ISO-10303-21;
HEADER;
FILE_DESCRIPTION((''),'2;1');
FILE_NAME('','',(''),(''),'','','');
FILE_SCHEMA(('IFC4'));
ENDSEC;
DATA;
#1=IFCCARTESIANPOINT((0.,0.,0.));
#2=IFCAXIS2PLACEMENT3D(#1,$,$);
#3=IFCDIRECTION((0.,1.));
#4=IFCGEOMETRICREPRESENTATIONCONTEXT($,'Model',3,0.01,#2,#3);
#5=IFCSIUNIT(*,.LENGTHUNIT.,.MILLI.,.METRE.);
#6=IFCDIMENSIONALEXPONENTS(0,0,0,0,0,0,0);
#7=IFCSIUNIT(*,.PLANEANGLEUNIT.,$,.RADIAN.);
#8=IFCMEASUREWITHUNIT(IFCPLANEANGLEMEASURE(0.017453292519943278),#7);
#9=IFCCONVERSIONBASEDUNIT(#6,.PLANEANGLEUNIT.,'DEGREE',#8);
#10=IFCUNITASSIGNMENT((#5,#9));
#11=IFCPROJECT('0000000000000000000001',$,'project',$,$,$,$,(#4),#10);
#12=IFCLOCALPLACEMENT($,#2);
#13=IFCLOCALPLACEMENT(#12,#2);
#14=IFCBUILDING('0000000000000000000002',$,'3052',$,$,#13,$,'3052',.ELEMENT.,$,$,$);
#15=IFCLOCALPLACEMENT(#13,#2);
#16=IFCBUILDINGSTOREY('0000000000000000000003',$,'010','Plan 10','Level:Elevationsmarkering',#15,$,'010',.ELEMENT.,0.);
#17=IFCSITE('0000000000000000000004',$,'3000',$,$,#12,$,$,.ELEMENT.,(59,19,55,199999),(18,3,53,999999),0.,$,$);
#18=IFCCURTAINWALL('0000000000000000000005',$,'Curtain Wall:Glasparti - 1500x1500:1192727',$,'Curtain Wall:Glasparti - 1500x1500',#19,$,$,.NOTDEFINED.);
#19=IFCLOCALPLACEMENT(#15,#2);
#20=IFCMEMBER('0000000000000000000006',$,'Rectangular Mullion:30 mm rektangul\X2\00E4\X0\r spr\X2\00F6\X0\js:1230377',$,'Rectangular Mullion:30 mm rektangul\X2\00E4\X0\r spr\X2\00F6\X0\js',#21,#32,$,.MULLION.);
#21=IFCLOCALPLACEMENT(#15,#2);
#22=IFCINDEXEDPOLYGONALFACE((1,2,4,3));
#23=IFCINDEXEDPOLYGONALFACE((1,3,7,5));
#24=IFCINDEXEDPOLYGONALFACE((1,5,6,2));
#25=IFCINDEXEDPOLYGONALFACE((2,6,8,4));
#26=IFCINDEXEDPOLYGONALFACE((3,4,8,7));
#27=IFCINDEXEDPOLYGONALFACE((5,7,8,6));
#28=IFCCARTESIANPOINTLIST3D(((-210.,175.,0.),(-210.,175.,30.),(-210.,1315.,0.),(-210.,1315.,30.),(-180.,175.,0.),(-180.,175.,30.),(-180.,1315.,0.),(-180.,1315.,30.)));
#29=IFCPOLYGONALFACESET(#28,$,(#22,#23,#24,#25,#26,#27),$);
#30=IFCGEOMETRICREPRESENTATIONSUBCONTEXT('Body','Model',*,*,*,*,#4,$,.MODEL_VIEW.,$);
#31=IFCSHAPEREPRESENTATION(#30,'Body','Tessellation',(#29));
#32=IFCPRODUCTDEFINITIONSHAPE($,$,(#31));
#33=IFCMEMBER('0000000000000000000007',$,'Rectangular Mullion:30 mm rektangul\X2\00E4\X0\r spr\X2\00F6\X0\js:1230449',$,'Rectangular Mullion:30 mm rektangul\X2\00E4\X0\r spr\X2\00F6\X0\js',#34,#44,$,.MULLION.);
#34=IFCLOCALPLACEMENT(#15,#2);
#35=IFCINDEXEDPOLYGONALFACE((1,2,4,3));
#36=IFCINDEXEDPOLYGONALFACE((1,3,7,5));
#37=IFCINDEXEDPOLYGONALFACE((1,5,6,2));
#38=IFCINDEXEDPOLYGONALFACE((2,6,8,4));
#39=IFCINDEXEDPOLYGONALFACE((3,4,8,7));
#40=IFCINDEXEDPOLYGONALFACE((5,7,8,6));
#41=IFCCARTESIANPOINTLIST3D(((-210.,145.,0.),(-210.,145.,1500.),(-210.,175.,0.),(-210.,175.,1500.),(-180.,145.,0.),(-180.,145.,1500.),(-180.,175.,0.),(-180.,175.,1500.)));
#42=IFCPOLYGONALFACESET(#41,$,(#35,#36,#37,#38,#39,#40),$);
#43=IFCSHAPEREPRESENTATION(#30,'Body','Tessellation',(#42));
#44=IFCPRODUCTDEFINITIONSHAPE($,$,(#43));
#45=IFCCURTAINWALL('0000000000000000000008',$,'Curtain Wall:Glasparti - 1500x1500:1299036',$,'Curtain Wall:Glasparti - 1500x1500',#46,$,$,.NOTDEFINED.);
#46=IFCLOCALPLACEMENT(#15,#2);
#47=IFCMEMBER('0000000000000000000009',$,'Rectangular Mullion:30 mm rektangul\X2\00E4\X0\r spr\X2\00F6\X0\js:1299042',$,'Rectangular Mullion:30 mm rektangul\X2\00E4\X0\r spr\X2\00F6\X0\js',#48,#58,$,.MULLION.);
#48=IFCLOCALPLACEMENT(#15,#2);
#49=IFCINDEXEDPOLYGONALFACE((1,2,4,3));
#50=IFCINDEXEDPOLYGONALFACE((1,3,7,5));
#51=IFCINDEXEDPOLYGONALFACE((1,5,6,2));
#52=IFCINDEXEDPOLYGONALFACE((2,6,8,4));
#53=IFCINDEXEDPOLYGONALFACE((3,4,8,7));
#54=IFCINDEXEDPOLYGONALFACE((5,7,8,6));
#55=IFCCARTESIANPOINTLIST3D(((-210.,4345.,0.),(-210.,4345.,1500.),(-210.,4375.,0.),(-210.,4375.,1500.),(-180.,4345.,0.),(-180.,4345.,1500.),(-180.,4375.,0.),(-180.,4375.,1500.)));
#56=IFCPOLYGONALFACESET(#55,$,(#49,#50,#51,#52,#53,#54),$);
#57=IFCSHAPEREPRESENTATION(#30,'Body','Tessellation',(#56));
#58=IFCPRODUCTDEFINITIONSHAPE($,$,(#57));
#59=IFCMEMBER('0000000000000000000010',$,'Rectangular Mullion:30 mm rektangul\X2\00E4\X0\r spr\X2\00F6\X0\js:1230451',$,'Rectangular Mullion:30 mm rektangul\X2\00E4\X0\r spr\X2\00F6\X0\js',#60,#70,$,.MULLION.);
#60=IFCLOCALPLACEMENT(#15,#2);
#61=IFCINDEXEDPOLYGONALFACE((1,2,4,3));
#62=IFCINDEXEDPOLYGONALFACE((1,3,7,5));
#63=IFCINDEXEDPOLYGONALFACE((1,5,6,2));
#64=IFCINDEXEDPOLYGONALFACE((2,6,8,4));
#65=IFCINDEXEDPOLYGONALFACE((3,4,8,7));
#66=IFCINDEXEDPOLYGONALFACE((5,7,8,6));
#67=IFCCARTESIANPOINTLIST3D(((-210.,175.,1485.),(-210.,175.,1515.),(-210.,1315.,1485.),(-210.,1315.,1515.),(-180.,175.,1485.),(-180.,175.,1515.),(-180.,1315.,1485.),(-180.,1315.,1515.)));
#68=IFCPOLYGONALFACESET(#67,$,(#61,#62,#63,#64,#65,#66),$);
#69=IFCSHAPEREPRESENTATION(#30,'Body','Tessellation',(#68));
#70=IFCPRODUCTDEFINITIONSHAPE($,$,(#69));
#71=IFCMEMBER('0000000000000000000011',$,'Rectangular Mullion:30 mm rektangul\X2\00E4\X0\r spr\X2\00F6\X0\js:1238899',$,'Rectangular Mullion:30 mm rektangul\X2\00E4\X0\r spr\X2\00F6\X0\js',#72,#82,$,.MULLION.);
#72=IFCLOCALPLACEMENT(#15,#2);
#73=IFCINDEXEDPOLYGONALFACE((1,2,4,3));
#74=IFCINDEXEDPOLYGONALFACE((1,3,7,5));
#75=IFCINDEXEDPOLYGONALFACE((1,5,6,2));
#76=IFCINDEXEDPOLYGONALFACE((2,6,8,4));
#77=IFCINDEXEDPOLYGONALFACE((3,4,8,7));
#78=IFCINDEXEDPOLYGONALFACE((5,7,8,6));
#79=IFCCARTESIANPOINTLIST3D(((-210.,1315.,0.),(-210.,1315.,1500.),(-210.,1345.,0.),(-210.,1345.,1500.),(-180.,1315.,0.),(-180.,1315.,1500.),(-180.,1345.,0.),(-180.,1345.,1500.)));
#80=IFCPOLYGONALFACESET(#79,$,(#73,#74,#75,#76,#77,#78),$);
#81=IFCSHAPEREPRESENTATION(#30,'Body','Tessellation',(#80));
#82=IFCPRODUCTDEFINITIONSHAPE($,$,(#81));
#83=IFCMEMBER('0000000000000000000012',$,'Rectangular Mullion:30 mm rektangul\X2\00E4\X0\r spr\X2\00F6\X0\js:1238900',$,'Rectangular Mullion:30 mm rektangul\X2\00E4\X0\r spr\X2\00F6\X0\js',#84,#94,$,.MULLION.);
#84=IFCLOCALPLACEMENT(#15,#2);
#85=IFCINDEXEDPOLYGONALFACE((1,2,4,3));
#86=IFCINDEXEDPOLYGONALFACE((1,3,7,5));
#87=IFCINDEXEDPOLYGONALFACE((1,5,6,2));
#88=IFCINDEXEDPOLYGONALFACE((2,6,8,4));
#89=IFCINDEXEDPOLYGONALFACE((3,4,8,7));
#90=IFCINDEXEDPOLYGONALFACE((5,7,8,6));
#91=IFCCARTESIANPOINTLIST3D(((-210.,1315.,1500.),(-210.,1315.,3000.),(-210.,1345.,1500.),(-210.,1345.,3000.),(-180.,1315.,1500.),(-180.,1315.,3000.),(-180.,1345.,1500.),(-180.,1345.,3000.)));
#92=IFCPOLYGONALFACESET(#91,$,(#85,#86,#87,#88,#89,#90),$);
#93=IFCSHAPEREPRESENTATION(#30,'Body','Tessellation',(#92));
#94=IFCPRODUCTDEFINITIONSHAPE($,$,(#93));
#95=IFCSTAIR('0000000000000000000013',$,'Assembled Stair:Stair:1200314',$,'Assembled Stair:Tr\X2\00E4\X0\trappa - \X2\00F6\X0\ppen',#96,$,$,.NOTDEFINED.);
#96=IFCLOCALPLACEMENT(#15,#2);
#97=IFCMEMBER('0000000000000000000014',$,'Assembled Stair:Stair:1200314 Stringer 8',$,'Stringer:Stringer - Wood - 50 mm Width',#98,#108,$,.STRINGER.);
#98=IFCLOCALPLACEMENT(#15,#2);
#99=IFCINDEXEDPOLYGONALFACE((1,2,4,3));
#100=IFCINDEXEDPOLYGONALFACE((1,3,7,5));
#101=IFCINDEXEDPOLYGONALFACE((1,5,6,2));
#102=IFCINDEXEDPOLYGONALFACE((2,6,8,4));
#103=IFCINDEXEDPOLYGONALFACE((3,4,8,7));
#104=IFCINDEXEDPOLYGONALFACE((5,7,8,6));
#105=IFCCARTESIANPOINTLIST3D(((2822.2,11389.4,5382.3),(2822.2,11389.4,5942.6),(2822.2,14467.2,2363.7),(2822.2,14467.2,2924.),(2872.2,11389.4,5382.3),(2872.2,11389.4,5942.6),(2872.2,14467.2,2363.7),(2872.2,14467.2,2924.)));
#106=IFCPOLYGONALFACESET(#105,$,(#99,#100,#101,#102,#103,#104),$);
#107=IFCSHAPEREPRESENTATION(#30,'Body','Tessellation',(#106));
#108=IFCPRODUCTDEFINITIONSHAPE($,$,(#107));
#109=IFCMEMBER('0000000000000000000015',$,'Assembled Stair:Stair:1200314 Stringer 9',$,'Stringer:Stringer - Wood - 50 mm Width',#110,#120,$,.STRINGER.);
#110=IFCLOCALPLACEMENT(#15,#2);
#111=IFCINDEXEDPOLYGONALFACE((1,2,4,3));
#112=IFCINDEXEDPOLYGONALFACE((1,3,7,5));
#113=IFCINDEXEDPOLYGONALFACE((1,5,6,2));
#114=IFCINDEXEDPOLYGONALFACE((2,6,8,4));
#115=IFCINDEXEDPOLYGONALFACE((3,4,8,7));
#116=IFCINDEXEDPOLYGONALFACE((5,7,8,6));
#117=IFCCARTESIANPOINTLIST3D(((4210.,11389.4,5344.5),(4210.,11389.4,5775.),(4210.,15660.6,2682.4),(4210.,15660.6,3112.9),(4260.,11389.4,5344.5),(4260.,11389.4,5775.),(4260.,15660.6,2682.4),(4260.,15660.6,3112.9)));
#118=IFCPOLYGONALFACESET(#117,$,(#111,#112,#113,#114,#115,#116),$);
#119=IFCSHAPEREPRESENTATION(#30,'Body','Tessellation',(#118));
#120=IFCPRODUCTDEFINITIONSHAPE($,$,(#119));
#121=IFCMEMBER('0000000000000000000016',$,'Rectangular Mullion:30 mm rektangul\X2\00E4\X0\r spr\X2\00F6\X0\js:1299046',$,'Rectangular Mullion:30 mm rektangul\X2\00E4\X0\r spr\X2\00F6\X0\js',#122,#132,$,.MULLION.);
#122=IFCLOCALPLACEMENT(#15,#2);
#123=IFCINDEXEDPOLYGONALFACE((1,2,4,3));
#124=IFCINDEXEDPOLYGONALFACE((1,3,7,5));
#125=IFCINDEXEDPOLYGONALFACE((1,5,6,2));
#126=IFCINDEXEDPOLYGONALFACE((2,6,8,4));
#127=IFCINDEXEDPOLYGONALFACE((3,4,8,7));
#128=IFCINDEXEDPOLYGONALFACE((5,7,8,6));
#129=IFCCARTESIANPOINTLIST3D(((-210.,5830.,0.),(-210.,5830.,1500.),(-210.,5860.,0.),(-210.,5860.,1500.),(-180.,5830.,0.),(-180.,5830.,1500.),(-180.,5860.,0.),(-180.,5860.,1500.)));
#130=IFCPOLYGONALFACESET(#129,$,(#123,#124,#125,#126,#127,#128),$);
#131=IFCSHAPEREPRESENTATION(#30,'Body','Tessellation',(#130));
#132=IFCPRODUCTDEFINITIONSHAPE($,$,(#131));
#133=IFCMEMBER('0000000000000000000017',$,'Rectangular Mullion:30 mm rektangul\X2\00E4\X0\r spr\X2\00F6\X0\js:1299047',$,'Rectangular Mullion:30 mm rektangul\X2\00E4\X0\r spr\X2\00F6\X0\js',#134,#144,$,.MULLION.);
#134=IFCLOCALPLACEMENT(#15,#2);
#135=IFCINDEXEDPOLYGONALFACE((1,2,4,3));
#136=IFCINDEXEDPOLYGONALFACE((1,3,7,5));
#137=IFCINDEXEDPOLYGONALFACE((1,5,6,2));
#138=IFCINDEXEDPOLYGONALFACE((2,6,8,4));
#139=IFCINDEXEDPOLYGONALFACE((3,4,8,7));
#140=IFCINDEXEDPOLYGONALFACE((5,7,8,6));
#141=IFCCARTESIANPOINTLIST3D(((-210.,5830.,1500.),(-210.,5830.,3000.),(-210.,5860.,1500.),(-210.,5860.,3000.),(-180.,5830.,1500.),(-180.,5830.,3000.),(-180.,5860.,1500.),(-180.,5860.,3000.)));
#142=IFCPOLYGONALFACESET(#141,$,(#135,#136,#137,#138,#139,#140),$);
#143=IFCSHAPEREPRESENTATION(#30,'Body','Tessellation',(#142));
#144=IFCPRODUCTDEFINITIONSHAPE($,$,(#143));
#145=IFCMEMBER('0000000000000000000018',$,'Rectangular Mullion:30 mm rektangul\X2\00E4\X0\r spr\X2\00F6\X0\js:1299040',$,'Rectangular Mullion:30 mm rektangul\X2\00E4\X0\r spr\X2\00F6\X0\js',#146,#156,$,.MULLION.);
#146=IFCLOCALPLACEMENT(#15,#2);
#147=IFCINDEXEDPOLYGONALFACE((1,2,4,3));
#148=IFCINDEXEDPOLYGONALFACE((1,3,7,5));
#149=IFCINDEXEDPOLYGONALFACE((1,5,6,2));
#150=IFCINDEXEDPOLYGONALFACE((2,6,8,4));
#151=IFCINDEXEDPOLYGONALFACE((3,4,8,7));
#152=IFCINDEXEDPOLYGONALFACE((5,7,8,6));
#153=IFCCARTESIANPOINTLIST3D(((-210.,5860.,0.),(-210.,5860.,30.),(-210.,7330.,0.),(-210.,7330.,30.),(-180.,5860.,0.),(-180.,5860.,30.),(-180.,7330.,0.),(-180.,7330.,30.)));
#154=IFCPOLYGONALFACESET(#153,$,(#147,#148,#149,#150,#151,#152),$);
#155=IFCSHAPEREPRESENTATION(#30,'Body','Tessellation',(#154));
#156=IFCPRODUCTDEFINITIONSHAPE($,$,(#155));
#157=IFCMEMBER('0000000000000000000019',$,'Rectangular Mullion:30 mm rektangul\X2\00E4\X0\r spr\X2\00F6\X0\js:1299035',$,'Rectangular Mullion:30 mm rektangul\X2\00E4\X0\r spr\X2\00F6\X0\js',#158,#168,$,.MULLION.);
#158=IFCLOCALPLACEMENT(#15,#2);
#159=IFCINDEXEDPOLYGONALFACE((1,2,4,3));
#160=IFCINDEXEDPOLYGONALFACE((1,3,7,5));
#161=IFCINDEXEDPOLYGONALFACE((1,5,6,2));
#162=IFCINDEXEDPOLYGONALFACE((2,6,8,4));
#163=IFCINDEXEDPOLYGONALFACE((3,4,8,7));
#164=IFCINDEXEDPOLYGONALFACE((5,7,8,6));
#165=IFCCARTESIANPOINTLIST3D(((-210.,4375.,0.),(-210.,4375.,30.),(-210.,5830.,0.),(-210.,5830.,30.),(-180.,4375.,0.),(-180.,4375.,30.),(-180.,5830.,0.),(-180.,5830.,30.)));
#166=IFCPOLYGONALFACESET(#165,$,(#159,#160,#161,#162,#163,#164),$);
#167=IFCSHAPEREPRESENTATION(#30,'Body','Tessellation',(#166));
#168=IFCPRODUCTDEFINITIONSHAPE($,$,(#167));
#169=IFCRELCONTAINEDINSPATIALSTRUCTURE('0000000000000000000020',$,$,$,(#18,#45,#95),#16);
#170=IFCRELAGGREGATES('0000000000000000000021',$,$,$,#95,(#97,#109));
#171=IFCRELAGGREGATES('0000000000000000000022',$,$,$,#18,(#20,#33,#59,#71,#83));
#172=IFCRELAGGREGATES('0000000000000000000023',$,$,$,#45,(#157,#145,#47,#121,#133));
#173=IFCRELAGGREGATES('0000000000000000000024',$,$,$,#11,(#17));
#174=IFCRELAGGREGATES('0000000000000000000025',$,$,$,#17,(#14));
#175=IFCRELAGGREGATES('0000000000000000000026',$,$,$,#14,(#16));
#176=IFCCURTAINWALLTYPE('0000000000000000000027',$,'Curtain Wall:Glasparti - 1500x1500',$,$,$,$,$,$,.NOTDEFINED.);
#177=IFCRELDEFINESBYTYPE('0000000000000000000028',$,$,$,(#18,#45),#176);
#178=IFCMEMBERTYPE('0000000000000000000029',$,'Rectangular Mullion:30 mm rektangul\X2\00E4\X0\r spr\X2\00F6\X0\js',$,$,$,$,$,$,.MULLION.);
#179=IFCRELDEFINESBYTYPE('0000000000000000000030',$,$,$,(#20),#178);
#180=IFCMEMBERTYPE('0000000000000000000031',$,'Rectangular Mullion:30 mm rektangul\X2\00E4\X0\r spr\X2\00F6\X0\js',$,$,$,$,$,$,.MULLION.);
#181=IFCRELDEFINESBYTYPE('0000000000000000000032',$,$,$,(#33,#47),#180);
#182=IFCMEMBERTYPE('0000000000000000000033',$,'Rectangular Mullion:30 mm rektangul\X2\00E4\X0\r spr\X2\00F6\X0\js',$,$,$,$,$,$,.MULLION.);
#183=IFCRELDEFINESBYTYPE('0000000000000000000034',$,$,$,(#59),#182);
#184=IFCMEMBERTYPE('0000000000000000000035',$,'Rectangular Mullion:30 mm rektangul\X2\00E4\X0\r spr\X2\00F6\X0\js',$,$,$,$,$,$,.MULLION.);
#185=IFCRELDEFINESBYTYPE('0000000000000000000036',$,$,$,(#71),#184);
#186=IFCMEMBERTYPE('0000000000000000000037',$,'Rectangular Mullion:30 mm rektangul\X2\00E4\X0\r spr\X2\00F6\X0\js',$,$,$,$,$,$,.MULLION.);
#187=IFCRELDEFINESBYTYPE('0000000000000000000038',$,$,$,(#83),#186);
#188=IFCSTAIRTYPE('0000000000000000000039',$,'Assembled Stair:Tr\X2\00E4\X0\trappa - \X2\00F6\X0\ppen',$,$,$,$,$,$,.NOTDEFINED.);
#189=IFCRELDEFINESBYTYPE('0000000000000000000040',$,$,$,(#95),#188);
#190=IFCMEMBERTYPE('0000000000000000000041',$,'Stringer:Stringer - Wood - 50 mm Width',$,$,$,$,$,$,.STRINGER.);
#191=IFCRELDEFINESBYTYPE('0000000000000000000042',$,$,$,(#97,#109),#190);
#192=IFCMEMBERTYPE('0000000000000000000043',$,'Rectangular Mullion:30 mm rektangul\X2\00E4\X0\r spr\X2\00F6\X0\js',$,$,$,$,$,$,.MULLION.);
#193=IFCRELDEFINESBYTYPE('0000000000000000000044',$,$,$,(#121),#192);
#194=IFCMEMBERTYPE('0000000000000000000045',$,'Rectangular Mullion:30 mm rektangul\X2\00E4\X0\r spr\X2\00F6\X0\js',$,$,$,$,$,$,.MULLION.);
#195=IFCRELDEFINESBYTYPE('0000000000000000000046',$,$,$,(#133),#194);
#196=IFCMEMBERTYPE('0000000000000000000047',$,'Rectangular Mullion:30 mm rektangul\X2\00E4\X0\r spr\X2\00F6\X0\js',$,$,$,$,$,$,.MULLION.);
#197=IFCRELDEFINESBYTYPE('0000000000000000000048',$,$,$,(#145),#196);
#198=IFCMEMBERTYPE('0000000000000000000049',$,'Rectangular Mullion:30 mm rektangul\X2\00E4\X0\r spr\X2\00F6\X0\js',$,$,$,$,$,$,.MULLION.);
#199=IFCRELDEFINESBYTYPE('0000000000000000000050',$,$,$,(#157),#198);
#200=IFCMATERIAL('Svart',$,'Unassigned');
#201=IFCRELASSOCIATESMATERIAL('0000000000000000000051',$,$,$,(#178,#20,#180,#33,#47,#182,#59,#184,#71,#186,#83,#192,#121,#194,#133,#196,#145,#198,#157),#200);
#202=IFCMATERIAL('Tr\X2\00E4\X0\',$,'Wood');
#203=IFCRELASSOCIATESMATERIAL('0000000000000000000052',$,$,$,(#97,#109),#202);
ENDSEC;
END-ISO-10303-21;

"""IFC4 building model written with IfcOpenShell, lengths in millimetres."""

from ifc_helpers import new_model, entity, si_unit, converted_unit, direction, frame, origin, place, context, subcontext, project, spatial, indexed_curve, outline, extrude, source, transform, mapped, material, type_object, type_shapes, element, aggregate, save


model = new_model("IFC4")

# Units and contexts
model_context = context("Model", 3, precision=0.01, world=origin(), true_north=direction((0.0, 1.0)))
body_context = subcontext(model_context, "Body", "Model", "MODEL_VIEW")
ifc_project = project(units=[si_unit("LENGTHUNIT", "METRE", prefix="MILLI"), converted_unit("PLANEANGLEUNIT", "DEGREE", entity("IfcPlaneAngleMeasure", 0.017453292519943278), si_unit("PLANEANGLEUNIT", "RADIAN"), dimensions=[0, 0, 0, 0, 0, 0, 0])], contexts=[model_context])

# Site, building, storey
site_placement = place(None, origin())
site = spatial("IfcSite", under=ifc_project, at=site_placement, Name="3000", CompositionType="ELEMENT", RefLatitude=(59, 19, 55, 199999), RefLongitude=(18, 3, 53, 999999), RefElevation=0.0)
building_placement = place(site_placement, origin())
building = spatial("IfcBuilding", under=site, at=building_placement, Name="3052", LongName="3052", CompositionType="ELEMENT")
storey_placement = place(building_placement, origin())
storey = spatial("IfcBuildingStorey", under=building, at=storey_placement, Name="010", Description="Plan 10", ObjectType="Level:Elevationsmarkering", LongName="010", CompositionType="ELEMENT", Elevation=0.0)

# Curtain wall, members
curtain_wall_type = type_object("IfcCurtainWallType", Name="Curtain Wall:Glasparti - 1500x1500", PredefinedType="NOTDEFINED")
curtain_wall_1_placement = place(storey_placement, origin())
curtain_wall_1 = element("IfcCurtainWall", 1, at=curtain_wall_1_placement, inside=storey, type_object=curtain_wall_type, Name="Curtain Wall:Glasparti - 1500x1500:1192727", ObjectType="Curtain Wall:Glasparti - 1500x1500", PredefinedType="NOTDEFINED")
ifc_material_1 = material(Name="Svart", Category="Unassigned")
member_type_1 = type_object("IfcMemberType", Name="Rectangular Mullion:30 mm rektangulär spröjs", PredefinedType="MULLION", material=ifc_material_1)
shared_shape_1 = source(origin(), body_context, "Body", "SweptSolid", [
    extrude(outline(indexed_curve([(-15.0, -15.0), (15.0, -15.0), (15.0, 15.0), (-15.0, 15.0), (-15.0, -15.0)], self_intersect=False)), frame((-15.0, 0.0, -1140.0), z_axis=(0.0, 0.0, 1.0), x_axis=(-1.0, 0.0, 0.0)), (0.0, 0.0, 1.0), 1140.0),
])
type_shapes(member_type_1, [shared_shape_1])
member_1_placement = place(curtain_wall_1_placement, frame((-195.0, 175.0, 0.0), z_axis=(0.0, -1.0, 0.0), x_axis=(0.0, 0.0, -1.0)))
member_1 = element("IfcMember", 2, at=member_1_placement, type_object=member_type_1, material=ifc_material_1, Name="Rectangular Mullion:30 mm rektangulär spröjs:1230377", ObjectType="Rectangular Mullion:30 mm rektangulär spröjs", PredefinedType="MULLION", context=body_context, shape_type="MappedRepresentation", body=[
    mapped(shared_shape_1, transform((0.0, 0.0, 0.0), scale=1.0)),
])
member_type_2 = type_object("IfcMemberType", Name="Rectangular Mullion:30 mm rektangulär spröjs", PredefinedType="MULLION", material=ifc_material_1)
shared_shape_2 = source(origin(), body_context, "Body", "SweptSolid", [
    extrude(outline(indexed_curve([(-15.0, -15.0), (15.0, -15.0), (15.0, 15.0), (-15.0, 15.0), (-15.0, -15.0)], self_intersect=False)), frame((-15.0, 0.0, -1500.0), z_axis=(0.0, 0.0, 1.0), x_axis=(-1.0, 0.0, 0.0)), (0.0, 0.0, 1.0), 1500.0),
])
type_shapes(member_type_2, [shared_shape_2])
member_2_placement = place(curtain_wall_1_placement, frame((-195.0, 145.0, 1500.0), z_axis=(0.0, 0.0, 1.0), x_axis=(0.0, -1.0, 0.0)))
member_2 = element("IfcMember", 3, at=member_2_placement, type_object=member_type_2, material=ifc_material_1, Name="Rectangular Mullion:30 mm rektangulär spröjs:1230449", ObjectType="Rectangular Mullion:30 mm rektangulär spröjs", PredefinedType="MULLION", context=body_context, shape_type="MappedRepresentation", body=[
    mapped(shared_shape_2, transform((0.0, 0.0, 0.0), scale=1.0)),
])

# Curtain wall, member
curtain_wall_2_placement = place(storey_placement, origin())
curtain_wall_2 = element("IfcCurtainWall", 4, at=curtain_wall_2_placement, inside=storey, type_object=curtain_wall_type, Name="Curtain Wall:Glasparti - 1500x1500:1299036", ObjectType="Curtain Wall:Glasparti - 1500x1500", PredefinedType="NOTDEFINED")
member_3_placement = place(curtain_wall_2_placement, frame((-195.0, 4345.0, 1500.0), z_axis=(0.0, 0.0, 1.0), x_axis=(0.0, -1.0, 0.0)))
member_3 = element("IfcMember", 5, at=member_3_placement, type_object=member_type_2, material=ifc_material_1, Name="Rectangular Mullion:30 mm rektangulär spröjs:1299042", ObjectType="Rectangular Mullion:30 mm rektangulär spröjs", PredefinedType="MULLION", context=body_context, shape_type="MappedRepresentation", body=[
    mapped(shared_shape_2, transform((0.0, 0.0, 0.0), scale=1.0)),
])

# Members
member_type_3 = type_object("IfcMemberType", Name="Rectangular Mullion:30 mm rektangulär spröjs", PredefinedType="MULLION", material=ifc_material_1)
shared_shape_3 = source(origin(), body_context, "Body", "SweptSolid", [
    extrude(outline(indexed_curve([(-15.0, -15.0), (15.0, -15.0), (15.0, 15.0), (-15.0, 15.0), (-15.0, -15.0)], self_intersect=False)), frame((0.0, 0.0, -1140.0), z_axis=(0.0, 0.0, 1.0), x_axis=(-1.0, 0.0, 0.0)), (0.0, 0.0, 1.0), 1140.0),
])
type_shapes(member_type_3, [shared_shape_3])
member_4_placement = place(curtain_wall_1_placement, frame((-195.0, 1315.0, 1500.0), z_axis=(0.0, 1.0, 0.0), x_axis=(0.0, 0.0, 1.0)))
member_4 = element("IfcMember", 6, at=member_4_placement, type_object=member_type_3, material=ifc_material_1, Name="Rectangular Mullion:30 mm rektangulär spröjs:1230451", ObjectType="Rectangular Mullion:30 mm rektangulär spröjs", PredefinedType="MULLION", context=body_context, shape_type="MappedRepresentation", body=[
    mapped(shared_shape_3, transform((0.0, 0.0, 0.0), scale=1.0)),
])
member_type_4 = type_object("IfcMemberType", Name="Rectangular Mullion:30 mm rektangulär spröjs", PredefinedType="MULLION", material=ifc_material_1)
shared_shape_4 = source(origin(), body_context, "Body", "SweptSolid", [
    extrude(outline(indexed_curve([(-15.0, -15.0), (15.0, -15.0), (15.0, 15.0), (-15.0, 15.0), (-15.0, -15.0)], self_intersect=False)), frame((-15.0, 0.0, -1500.0), z_axis=(0.0, 0.0, 1.0), x_axis=(-1.0, 0.0, 0.0)), (0.0, 0.0, 1.0), 1500.0),
])
type_shapes(member_type_4, [shared_shape_4])
member_5_placement = place(curtain_wall_1_placement, frame((-195.0, 1345.0, 0.0), z_axis=(0.0, 0.0, -1.0), x_axis=(0.0, 1.0, 0.0)))
member_5 = element("IfcMember", 7, at=member_5_placement, type_object=member_type_4, material=ifc_material_1, Name="Rectangular Mullion:30 mm rektangulär spröjs:1238899", ObjectType="Rectangular Mullion:30 mm rektangulär spröjs", PredefinedType="MULLION", context=body_context, shape_type="MappedRepresentation", body=[
    mapped(shared_shape_4, transform((0.0, 0.0, 0.0), scale=1.0)),
])
member_type_5 = type_object("IfcMemberType", Name="Rectangular Mullion:30 mm rektangulär spröjs", PredefinedType="MULLION", material=ifc_material_1)
shared_shape_5 = source(origin(), body_context, "Body", "SweptSolid", [
    extrude(outline(indexed_curve([(-15.0, -15.0), (15.0, -15.0), (15.0, 15.0), (-15.0, 15.0), (-15.0, -15.0)], self_intersect=False)), frame((-15.0, 0.0, -1500.0), z_axis=(0.0, 0.0, 1.0), x_axis=(-1.0, 0.0, 0.0)), (0.0, 0.0, 1.0), 1500.0),
])
type_shapes(member_type_5, [shared_shape_5])
member_6_placement = place(curtain_wall_1_placement, frame((-195.0, 1345.0, 1500.0), z_axis=(0.0, 0.0, -1.0), x_axis=(0.0, 1.0, 0.0)))
member_6 = element("IfcMember", 8, at=member_6_placement, type_object=member_type_5, material=ifc_material_1, Name="Rectangular Mullion:30 mm rektangulär spröjs:1238900", ObjectType="Rectangular Mullion:30 mm rektangulär spröjs", PredefinedType="MULLION", context=body_context, shape_type="MappedRepresentation", body=[
    mapped(shared_shape_5, transform((0.0, 0.0, 0.0), scale=1.0)),
])

# Stair, members
stair_type = type_object("IfcStairType", Name="Assembled Stair:Trätrappa - öppen", PredefinedType="NOTDEFINED")
stair_placement = place(storey_placement, origin())
stair = element("IfcStair", 9, at=stair_placement, inside=storey, type_object=stair_type, Name="Assembled Stair:Stair:1200314", ObjectType="Assembled Stair:Trätrappa - öppen", PredefinedType="NOTDEFINED")
ifc_material_2 = material(Name="Trä", Category="Wood")
member_type_6 = type_object("IfcMemberType", Name="Stringer:Stringer - Wood - 50 mm Width", PredefinedType="STRINGER")
member_7_placement = place(stair_placement, origin())
member_7 = element("IfcMember", 10, at=member_7_placement, type_object=member_type_6, material=ifc_material_2, Name="Assembled Stair:Stair:1200314 Stringer 8", ObjectType="Stringer:Stringer - Wood - 50 mm Width", PredefinedType="STRINGER", context=body_context, shape_type="SweptSolid", body=[
    extrude(outline(indexed_curve([(-1959.3, -200.0), (2351.7, -200.0), (1959.3, 200.0), (-2351.7, 200.0), (-1959.3, -200.0)], self_intersect=False)), frame((2822.2, 12928.3, 4153.1), z_axis=(1.0, 0.0, 0.0), x_axis=(0.0, -0.713941, 0.700206)), (0.0, 0.0, 1.0), 50.0),
])
member_8_placement = place(stair_placement, origin())
member_8 = element("IfcMember", 11, at=member_8_placement, type_object=member_type_6, material=ifc_material_2, Name="Assembled Stair:Stair:1200314 Stringer 9", ObjectType="Stringer:Stringer - Wood - 50 mm Width", PredefinedType="STRINGER", context=body_context, shape_type="SweptSolid", body=[
    extrude(outline(indexed_curve([(-2402.6, -182.7), (2630.3, -182.7), (2402.6, 182.7), (-2630.3, 182.7), (-2402.6, -182.7)], self_intersect=False)), frame((4210.0, 13525.0, 4228.7), z_axis=(1.0, 0.0, 0.0), x_axis=(0.0, -0.848663, 0.528934)), (0.0, 0.0, 1.0), 50.0),
])
aggregate(stair, [member_7, member_8])

# Members
member_type_7 = type_object("IfcMemberType", Name="Rectangular Mullion:30 mm rektangulär spröjs", PredefinedType="MULLION", material=ifc_material_1)
shared_shape_6 = source(origin(), body_context, "Body", "SweptSolid", [
    extrude(outline(indexed_curve([(-15.0, -15.0), (15.0, -15.0), (15.0, 15.0), (-15.0, 15.0), (-15.0, -15.0)], self_intersect=False)), frame((0.0, 0.0, -1500.0), z_axis=(0.0, 0.0, 1.0), x_axis=(-1.0, 0.0, 0.0)), (0.0, 0.0, 1.0), 1500.0),
])
type_shapes(member_type_7, [shared_shape_6])
member_9_placement = place(curtain_wall_2_placement, frame((-195.0, 5845.0, 0.0), z_axis=(0.0, 0.0, -1.0), x_axis=(0.0, 1.0, 0.0)))
member_9 = element("IfcMember", 12, at=member_9_placement, type_object=member_type_7, material=ifc_material_1, Name="Rectangular Mullion:30 mm rektangulär spröjs:1299046", ObjectType="Rectangular Mullion:30 mm rektangulär spröjs", PredefinedType="MULLION", context=body_context, shape_type="MappedRepresentation", body=[
    mapped(shared_shape_6, transform((0.0, 0.0, 0.0), scale=1.0)),
])
member_type_8 = type_object("IfcMemberType", Name="Rectangular Mullion:30 mm rektangulär spröjs", PredefinedType="MULLION", material=ifc_material_1)
shared_shape_7 = source(origin(), body_context, "Body", "SweptSolid", [
    extrude(outline(indexed_curve([(-15.0, -15.0), (15.0, -15.0), (15.0, 15.0), (-15.0, 15.0), (-15.0, -15.0)], self_intersect=False)), frame((0.0, 0.0, -1500.0), z_axis=(0.0, 0.0, 1.0), x_axis=(-1.0, 0.0, 0.0)), (0.0, 0.0, 1.0), 1500.0),
])
type_shapes(member_type_8, [shared_shape_7])
member_10_placement = place(curtain_wall_2_placement, frame((-195.0, 5845.0, 1500.0), z_axis=(0.0, 0.0, -1.0), x_axis=(0.0, 1.0, 0.0)))
member_10 = element("IfcMember", 13, at=member_10_placement, type_object=member_type_8, material=ifc_material_1, Name="Rectangular Mullion:30 mm rektangulär spröjs:1299047", ObjectType="Rectangular Mullion:30 mm rektangulär spröjs", PredefinedType="MULLION", context=body_context, shape_type="MappedRepresentation", body=[
    mapped(shared_shape_7, transform((0.0, 0.0, 0.0), scale=1.0)),
])
member_type_9 = type_object("IfcMemberType", Name="Rectangular Mullion:30 mm rektangulär spröjs", PredefinedType="MULLION", material=ifc_material_1)
shared_shape_8 = source(origin(), body_context, "Body", "SweptSolid", [
    extrude(outline(indexed_curve([(-15.0, -15.0), (15.0, -15.0), (15.0, 15.0), (-15.0, 15.0), (-15.0, -15.0)], self_intersect=False)), frame((-15.0, 0.0, -1470.0), z_axis=(0.0, 0.0, 1.0), x_axis=(-1.0, 0.0, 0.0)), (0.0, 0.0, 1.0), 1470.0),
])
type_shapes(member_type_9, [shared_shape_8])
member_11_placement = place(curtain_wall_2_placement, frame((-195.0, 5860.0, 0.0), z_axis=(0.0, -1.0, 0.0), x_axis=(0.0, 0.0, -1.0)))
member_11 = element("IfcMember", 14, at=member_11_placement, type_object=member_type_9, material=ifc_material_1, Name="Rectangular Mullion:30 mm rektangulär spröjs:1299040", ObjectType="Rectangular Mullion:30 mm rektangulär spröjs", PredefinedType="MULLION", context=body_context, shape_type="MappedRepresentation", body=[
    mapped(shared_shape_8, transform((0.0, 0.0, 0.0), scale=1.0)),
])
member_type_10 = type_object("IfcMemberType", Name="Rectangular Mullion:30 mm rektangulär spröjs", PredefinedType="MULLION", material=ifc_material_1)
shared_shape_9 = source(origin(), body_context, "Body", "SweptSolid", [
    extrude(outline(indexed_curve([(-15.0, -15.0), (15.0, -15.0), (15.0, 15.0), (-15.0, 15.0), (-15.0, -15.0)], self_intersect=False)), frame((-15.0, 0.0, -1455.0), z_axis=(0.0, 0.0, 1.0), x_axis=(-1.0, 0.0, 0.0)), (0.0, 0.0, 1.0), 1455.0),
])
type_shapes(member_type_10, [shared_shape_9])
member_12_placement = place(curtain_wall_2_placement, frame((-195.0, 4375.0, 0.0), z_axis=(0.0, -1.0, 0.0), x_axis=(0.0, 0.0, -1.0)))
member_12 = element("IfcMember", 15, at=member_12_placement, type_object=member_type_10, material=ifc_material_1, Name="Rectangular Mullion:30 mm rektangulär spröjs:1299035", ObjectType="Rectangular Mullion:30 mm rektangulär spröjs", PredefinedType="MULLION", context=body_context, shape_type="MappedRepresentation", body=[
    mapped(shared_shape_9, transform((0.0, 0.0, 0.0), scale=1.0)),
])

aggregate(curtain_wall_1, [member_1, member_2, member_4, member_5, member_6])
aggregate(curtain_wall_2, [member_12, member_11, member_3, member_9, member_10])

save(model, "model.ifc")
